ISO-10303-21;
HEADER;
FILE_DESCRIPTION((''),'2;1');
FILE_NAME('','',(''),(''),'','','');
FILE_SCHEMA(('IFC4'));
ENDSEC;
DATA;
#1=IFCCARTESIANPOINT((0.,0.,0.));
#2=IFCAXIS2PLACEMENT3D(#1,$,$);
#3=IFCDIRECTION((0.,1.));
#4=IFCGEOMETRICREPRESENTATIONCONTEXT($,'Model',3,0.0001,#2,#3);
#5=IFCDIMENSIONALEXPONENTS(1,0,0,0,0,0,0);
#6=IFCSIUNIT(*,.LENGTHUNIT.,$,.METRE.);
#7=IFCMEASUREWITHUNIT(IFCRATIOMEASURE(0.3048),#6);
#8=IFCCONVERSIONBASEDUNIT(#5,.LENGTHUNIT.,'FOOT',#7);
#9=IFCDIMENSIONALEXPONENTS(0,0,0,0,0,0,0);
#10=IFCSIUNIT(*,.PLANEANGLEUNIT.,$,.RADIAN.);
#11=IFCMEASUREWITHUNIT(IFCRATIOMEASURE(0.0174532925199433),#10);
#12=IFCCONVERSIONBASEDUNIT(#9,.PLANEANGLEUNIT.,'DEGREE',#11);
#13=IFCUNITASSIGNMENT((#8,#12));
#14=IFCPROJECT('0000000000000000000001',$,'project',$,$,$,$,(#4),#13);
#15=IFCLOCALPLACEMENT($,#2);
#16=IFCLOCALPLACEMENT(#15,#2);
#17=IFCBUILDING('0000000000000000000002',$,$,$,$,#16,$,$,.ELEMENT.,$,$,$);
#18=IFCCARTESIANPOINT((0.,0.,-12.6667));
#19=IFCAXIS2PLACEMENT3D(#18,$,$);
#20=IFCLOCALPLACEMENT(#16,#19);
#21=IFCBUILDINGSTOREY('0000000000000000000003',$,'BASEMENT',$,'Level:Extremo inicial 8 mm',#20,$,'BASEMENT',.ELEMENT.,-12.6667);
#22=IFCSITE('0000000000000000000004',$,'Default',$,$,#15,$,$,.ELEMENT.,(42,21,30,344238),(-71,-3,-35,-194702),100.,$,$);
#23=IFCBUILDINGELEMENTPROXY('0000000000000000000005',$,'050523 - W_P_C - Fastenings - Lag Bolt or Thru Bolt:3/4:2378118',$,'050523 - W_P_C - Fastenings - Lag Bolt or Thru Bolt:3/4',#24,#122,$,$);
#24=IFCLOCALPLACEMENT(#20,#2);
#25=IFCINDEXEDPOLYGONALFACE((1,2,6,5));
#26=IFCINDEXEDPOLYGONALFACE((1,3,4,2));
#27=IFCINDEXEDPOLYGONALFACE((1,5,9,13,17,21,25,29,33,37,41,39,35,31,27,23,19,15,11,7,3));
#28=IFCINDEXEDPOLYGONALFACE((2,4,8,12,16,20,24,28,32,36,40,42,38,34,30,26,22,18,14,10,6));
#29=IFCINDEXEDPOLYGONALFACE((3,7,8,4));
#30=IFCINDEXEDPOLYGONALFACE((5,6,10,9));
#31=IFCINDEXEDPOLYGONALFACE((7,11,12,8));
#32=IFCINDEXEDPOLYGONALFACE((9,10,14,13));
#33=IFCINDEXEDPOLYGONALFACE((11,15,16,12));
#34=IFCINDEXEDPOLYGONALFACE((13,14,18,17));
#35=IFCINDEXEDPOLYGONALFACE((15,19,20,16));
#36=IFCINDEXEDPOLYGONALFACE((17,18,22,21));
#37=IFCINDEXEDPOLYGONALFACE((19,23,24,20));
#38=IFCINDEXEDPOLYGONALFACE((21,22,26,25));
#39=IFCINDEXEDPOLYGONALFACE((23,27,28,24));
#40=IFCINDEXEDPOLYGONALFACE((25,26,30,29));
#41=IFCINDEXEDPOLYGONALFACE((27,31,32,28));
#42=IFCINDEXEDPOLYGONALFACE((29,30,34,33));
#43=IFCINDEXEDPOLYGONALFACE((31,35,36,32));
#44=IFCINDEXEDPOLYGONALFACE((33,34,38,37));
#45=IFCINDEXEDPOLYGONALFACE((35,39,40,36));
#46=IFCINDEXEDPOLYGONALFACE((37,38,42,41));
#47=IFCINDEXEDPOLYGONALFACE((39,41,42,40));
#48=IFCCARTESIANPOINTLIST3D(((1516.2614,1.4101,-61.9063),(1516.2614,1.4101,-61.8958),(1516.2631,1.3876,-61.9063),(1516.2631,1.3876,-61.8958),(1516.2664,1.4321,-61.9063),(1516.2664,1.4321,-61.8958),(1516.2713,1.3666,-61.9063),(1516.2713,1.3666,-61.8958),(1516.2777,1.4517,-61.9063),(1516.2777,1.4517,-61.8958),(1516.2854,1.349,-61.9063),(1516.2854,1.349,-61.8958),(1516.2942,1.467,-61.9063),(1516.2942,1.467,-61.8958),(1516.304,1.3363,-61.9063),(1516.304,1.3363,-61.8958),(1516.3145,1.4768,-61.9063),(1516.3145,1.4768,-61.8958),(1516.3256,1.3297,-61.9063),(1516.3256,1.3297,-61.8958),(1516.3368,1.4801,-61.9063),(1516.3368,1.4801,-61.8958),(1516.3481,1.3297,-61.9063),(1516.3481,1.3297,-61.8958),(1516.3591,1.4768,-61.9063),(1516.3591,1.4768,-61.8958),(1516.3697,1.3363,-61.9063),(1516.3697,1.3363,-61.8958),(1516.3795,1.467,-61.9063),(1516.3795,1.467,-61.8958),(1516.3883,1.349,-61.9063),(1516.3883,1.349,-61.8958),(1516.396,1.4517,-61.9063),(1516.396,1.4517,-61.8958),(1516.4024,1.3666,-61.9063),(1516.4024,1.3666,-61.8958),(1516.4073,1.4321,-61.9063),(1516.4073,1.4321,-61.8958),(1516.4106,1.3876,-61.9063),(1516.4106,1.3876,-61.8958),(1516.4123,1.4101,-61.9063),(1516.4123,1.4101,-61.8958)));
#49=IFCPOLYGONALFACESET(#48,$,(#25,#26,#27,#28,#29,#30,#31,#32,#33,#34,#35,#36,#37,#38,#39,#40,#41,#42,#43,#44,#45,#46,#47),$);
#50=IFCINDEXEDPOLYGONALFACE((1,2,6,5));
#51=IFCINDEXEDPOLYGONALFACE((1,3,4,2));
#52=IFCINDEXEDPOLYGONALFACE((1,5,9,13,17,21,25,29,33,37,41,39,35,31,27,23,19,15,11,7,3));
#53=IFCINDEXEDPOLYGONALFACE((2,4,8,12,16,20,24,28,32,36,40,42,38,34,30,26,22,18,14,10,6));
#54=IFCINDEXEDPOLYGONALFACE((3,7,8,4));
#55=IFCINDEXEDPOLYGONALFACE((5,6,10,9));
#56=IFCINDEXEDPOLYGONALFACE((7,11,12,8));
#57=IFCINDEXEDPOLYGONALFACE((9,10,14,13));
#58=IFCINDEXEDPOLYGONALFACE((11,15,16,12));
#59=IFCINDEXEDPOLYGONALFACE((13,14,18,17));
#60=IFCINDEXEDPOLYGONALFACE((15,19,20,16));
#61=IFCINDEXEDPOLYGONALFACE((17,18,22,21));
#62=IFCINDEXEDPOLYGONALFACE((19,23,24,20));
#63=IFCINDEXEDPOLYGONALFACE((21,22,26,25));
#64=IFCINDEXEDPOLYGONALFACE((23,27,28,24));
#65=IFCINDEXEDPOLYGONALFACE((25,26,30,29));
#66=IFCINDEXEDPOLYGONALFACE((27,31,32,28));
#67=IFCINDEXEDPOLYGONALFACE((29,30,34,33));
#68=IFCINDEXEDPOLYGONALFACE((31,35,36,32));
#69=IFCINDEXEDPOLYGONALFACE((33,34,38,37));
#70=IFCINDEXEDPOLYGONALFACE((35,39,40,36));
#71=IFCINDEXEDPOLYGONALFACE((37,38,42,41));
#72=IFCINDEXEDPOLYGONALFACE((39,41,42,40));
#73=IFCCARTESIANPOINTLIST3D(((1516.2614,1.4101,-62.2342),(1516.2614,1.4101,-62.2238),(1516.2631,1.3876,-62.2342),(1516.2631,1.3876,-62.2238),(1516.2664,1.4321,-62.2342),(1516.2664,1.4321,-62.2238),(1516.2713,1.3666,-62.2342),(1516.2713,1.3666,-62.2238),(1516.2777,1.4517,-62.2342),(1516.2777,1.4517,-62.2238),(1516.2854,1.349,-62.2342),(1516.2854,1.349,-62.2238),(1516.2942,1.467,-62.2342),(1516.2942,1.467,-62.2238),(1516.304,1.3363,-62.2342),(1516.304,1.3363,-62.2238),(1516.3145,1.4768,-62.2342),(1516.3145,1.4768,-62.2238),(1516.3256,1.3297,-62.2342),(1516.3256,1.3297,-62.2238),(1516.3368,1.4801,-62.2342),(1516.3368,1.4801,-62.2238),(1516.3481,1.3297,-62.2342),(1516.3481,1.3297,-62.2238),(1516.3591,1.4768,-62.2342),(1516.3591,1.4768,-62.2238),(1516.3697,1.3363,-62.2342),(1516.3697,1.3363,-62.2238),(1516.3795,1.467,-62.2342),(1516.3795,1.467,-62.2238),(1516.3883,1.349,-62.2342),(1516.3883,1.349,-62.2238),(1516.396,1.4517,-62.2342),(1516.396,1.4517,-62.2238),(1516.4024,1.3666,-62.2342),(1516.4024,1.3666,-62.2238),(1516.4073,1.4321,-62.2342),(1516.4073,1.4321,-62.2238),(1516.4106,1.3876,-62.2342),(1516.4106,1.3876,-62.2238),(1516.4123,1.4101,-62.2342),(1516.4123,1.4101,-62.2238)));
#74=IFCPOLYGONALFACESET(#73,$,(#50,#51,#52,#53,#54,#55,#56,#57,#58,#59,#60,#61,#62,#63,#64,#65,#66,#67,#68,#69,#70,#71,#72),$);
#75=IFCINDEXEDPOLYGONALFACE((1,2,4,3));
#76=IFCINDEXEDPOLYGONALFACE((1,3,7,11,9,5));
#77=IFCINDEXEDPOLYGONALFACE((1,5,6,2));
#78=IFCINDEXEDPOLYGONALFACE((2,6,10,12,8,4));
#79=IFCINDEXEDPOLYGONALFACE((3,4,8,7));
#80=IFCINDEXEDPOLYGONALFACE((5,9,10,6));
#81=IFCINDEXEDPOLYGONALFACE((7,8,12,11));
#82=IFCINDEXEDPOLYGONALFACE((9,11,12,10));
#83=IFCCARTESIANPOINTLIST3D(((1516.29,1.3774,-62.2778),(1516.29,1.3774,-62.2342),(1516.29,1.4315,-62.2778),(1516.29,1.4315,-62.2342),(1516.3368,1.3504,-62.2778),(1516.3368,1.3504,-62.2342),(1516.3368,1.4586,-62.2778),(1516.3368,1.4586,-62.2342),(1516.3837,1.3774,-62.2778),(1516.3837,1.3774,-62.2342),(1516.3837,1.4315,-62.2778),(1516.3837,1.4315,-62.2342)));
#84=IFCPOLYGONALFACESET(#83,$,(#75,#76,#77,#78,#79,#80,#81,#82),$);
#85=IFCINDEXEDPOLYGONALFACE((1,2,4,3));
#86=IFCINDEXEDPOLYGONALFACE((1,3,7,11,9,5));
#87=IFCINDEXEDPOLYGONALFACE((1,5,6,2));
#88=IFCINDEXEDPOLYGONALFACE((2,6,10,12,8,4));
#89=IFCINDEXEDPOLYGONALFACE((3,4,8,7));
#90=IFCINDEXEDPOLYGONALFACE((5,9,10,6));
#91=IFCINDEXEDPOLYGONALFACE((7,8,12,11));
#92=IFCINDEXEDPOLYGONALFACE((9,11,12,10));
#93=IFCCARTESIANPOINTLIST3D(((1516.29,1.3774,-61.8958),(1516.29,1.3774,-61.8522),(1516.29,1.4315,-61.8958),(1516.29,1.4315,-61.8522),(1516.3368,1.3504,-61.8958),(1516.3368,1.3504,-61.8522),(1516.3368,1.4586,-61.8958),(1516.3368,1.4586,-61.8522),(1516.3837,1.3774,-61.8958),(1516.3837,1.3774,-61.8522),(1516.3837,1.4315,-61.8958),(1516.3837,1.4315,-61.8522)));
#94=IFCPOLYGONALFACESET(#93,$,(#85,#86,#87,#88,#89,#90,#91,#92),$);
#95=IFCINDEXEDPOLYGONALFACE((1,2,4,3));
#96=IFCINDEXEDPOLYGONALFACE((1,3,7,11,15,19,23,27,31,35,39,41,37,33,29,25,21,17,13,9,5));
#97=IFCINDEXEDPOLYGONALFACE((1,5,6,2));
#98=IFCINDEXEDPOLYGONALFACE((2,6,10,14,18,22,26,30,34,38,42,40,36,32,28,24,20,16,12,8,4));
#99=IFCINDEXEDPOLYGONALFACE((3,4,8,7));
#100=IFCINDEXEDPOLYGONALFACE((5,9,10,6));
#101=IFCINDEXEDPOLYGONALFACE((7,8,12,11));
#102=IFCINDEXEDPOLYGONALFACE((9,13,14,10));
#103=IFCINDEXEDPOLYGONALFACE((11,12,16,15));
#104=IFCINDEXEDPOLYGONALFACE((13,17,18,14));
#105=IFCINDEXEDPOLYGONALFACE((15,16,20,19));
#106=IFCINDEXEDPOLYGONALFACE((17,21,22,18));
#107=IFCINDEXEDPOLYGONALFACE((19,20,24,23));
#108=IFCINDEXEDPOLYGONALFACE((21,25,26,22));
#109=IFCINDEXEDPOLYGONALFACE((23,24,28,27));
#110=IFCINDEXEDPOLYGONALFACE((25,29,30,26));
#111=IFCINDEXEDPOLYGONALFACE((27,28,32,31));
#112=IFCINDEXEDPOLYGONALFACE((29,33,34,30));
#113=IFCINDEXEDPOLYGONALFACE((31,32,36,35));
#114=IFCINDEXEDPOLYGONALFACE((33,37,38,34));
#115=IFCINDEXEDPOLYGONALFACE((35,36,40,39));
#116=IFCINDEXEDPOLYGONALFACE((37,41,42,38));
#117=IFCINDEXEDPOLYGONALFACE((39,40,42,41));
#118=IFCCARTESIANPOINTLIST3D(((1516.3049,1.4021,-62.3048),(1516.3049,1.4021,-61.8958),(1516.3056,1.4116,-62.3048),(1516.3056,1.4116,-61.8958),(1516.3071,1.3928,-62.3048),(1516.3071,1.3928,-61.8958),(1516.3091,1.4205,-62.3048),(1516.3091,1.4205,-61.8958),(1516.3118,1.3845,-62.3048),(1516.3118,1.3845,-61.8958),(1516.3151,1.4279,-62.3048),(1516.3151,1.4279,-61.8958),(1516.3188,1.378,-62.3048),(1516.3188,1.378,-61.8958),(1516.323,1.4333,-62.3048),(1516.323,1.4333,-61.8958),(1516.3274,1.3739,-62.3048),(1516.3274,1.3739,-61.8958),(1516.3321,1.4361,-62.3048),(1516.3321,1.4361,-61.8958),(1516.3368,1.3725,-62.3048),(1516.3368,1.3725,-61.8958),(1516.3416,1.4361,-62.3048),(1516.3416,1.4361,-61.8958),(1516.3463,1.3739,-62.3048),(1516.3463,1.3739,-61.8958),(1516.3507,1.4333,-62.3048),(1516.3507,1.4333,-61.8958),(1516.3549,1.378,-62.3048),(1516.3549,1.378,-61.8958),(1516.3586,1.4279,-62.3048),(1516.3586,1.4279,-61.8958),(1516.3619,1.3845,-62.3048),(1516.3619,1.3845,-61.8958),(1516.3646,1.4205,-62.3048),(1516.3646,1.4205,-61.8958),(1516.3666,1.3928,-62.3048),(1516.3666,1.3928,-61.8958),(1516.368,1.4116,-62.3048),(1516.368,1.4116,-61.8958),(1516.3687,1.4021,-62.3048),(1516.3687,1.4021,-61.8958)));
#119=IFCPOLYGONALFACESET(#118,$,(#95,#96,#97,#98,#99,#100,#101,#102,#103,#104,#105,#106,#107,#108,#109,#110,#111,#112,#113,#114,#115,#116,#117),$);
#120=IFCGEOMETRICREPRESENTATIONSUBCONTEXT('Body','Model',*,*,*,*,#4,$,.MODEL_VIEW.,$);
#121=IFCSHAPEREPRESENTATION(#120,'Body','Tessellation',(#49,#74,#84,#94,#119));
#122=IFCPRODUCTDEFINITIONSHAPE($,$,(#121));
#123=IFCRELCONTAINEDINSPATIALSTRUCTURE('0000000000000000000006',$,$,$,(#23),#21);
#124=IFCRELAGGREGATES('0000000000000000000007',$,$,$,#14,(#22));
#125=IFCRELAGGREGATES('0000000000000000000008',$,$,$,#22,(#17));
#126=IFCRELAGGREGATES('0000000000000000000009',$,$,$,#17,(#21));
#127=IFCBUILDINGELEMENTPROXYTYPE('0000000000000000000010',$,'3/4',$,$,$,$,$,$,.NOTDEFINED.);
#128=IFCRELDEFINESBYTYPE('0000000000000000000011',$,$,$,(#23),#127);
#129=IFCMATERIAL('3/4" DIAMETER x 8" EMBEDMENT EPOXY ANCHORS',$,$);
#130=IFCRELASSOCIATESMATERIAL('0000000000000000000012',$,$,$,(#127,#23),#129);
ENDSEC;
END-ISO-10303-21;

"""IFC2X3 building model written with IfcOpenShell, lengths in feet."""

from ifc_helpers import new_model, entity, si_unit, converted_unit, direction, frame, frame_2d, origin, place, context, subcontext, project, spatial, polyline, circle, outline, extrude, source, transform, mapped, material, type_object, type_shapes, element, save


model = new_model("IFC2X3")

# Units and contexts
model_context = context("Model", 3, precision=0.0001, world=origin(), true_north=direction((0.0, 1.0)))
body_context = subcontext(model_context, "Body", "Model", "MODEL_VIEW")
ifc_project = project(units=[converted_unit("LENGTHUNIT", "FOOT", entity("IfcRatioMeasure", 0.3048), si_unit("LENGTHUNIT", "METRE"), dimensions=[1, 0, 0, 0, 0, 0, 0]), converted_unit("PLANEANGLEUNIT", "DEGREE", entity("IfcRatioMeasure", 0.0174532925199433), si_unit("PLANEANGLEUNIT", "RADIAN"), dimensions=[0, 0, 0, 0, 0, 0, 0])], contexts=[model_context])

# Site, building, storey
site_placement = place(None, origin())
site = spatial("IfcSite", under=ifc_project, at=site_placement, Name="Default", CompositionType="ELEMENT", RefLatitude=(42, 21, 30, 344238), RefLongitude=(-71, -3, -35, -194702), RefElevation=100.0)
building_placement = place(site_placement, origin())
building = spatial("IfcBuilding", under=site, at=building_placement, CompositionType="ELEMENT")
storey_placement = place(building_placement, frame((0.0, 0.0, -12.6667)))
storey = spatial("IfcBuildingStorey", under=building, at=storey_placement, Name="BASEMENT", ObjectType="Level:Extremo inicial 8 mm", LongName="BASEMENT", CompositionType="ELEMENT", Elevation=-12.6667)

# Building element proxy
ifc_material_1 = material(Name="3/4\" DIAMETER x 8\" EMBEDMENT EPOXY ANCHORS")
building_element_proxy_type_1 = type_object("IfcBuildingElementProxyType", Name="3/4", PredefinedType="NOTDEFINED", material=ifc_material_1)
shared_shape_1 = source(origin(), body_context, "Body", "SweptSolid", [
    extrude(circle(Radius=0.0757, at=frame_2d((0.0, 0.0), x_axis=(1.0, 0.0))), frame((0.0, 0.0, 0.0), z_axis=(0.0, 0.0, 1.0), x_axis=(0.0, 1.0, 0.0)), (0.0, 0.0, 1.0), 0.0104),
    extrude(circle(Radius=0.0757, at=frame_2d((0.0, 0.0), x_axis=(1.0, 0.0))), frame((0.0, 0.0, -0.3279), z_axis=(0.0, 0.0, 1.0), x_axis=(0.0, 1.0, 0.0)), (0.0, 0.0, 1.0), 0.0104),
    extrude(outline(polyline([(-0.0271, -0.0469), (0.0271, -0.0469), (0.0541, 0.0), (0.0271, 0.0469), (-0.0271, 0.0469), (-0.0541, 0.0), (-0.0271, -0.0469)])), frame((0.0, 0.0, -0.3716), z_axis=(0.0, 0.0, 1.0), x_axis=(0.0, -1.0, 0.0)), (0.0, 0.0, 1.0), 0.0437),
    extrude(outline(polyline([(-0.0271, -0.0469), (0.0271, -0.0469), (0.0541, 0.0), (0.0271, 0.0469), (-0.0271, 0.0469), (-0.0541, 0.0), (-0.0271, -0.0469)])), frame((0.0, 0.0, 0.0104), z_axis=(0.0, 0.0, 1.0), x_axis=(0.866025, -0.5, 0.0)), (0.0, 0.0, 1.0), 0.0437),
    extrude(circle(Radius=0.032, at=frame_2d((0.0, 0.0), x_axis=(1.0, 0.0))), frame((0.0, 0.0, -0.3986), z_axis=(0.0, 0.0, 1.0), x_axis=(0.0, -1.0, 0.0)), (0.0, 0.0, 1.0), 0.409),
])
type_shapes(building_element_proxy_type_1, [shared_shape_1])
proxy_1_placement = place(storey_placement, frame((1516.3368, 1.4045, -61.9063)))
element("IfcBuildingElementProxy", 1, at=proxy_1_placement, inside=storey, type_object=building_element_proxy_type_1, material=ifc_material_1, Name="050523 - W_P_C - Fastenings - Lag Bolt or Thru Bolt:3/4:2378118", ObjectType="050523 - W_P_C - Fastenings - Lag Bolt or Thru Bolt:3/4", context=body_context, shape_type="MappedRepresentation", body=[
    mapped(shared_shape_1, transform((0.0, 0.0, 0.0), scale=1.0)),
])

save(model, "model.ifc")
